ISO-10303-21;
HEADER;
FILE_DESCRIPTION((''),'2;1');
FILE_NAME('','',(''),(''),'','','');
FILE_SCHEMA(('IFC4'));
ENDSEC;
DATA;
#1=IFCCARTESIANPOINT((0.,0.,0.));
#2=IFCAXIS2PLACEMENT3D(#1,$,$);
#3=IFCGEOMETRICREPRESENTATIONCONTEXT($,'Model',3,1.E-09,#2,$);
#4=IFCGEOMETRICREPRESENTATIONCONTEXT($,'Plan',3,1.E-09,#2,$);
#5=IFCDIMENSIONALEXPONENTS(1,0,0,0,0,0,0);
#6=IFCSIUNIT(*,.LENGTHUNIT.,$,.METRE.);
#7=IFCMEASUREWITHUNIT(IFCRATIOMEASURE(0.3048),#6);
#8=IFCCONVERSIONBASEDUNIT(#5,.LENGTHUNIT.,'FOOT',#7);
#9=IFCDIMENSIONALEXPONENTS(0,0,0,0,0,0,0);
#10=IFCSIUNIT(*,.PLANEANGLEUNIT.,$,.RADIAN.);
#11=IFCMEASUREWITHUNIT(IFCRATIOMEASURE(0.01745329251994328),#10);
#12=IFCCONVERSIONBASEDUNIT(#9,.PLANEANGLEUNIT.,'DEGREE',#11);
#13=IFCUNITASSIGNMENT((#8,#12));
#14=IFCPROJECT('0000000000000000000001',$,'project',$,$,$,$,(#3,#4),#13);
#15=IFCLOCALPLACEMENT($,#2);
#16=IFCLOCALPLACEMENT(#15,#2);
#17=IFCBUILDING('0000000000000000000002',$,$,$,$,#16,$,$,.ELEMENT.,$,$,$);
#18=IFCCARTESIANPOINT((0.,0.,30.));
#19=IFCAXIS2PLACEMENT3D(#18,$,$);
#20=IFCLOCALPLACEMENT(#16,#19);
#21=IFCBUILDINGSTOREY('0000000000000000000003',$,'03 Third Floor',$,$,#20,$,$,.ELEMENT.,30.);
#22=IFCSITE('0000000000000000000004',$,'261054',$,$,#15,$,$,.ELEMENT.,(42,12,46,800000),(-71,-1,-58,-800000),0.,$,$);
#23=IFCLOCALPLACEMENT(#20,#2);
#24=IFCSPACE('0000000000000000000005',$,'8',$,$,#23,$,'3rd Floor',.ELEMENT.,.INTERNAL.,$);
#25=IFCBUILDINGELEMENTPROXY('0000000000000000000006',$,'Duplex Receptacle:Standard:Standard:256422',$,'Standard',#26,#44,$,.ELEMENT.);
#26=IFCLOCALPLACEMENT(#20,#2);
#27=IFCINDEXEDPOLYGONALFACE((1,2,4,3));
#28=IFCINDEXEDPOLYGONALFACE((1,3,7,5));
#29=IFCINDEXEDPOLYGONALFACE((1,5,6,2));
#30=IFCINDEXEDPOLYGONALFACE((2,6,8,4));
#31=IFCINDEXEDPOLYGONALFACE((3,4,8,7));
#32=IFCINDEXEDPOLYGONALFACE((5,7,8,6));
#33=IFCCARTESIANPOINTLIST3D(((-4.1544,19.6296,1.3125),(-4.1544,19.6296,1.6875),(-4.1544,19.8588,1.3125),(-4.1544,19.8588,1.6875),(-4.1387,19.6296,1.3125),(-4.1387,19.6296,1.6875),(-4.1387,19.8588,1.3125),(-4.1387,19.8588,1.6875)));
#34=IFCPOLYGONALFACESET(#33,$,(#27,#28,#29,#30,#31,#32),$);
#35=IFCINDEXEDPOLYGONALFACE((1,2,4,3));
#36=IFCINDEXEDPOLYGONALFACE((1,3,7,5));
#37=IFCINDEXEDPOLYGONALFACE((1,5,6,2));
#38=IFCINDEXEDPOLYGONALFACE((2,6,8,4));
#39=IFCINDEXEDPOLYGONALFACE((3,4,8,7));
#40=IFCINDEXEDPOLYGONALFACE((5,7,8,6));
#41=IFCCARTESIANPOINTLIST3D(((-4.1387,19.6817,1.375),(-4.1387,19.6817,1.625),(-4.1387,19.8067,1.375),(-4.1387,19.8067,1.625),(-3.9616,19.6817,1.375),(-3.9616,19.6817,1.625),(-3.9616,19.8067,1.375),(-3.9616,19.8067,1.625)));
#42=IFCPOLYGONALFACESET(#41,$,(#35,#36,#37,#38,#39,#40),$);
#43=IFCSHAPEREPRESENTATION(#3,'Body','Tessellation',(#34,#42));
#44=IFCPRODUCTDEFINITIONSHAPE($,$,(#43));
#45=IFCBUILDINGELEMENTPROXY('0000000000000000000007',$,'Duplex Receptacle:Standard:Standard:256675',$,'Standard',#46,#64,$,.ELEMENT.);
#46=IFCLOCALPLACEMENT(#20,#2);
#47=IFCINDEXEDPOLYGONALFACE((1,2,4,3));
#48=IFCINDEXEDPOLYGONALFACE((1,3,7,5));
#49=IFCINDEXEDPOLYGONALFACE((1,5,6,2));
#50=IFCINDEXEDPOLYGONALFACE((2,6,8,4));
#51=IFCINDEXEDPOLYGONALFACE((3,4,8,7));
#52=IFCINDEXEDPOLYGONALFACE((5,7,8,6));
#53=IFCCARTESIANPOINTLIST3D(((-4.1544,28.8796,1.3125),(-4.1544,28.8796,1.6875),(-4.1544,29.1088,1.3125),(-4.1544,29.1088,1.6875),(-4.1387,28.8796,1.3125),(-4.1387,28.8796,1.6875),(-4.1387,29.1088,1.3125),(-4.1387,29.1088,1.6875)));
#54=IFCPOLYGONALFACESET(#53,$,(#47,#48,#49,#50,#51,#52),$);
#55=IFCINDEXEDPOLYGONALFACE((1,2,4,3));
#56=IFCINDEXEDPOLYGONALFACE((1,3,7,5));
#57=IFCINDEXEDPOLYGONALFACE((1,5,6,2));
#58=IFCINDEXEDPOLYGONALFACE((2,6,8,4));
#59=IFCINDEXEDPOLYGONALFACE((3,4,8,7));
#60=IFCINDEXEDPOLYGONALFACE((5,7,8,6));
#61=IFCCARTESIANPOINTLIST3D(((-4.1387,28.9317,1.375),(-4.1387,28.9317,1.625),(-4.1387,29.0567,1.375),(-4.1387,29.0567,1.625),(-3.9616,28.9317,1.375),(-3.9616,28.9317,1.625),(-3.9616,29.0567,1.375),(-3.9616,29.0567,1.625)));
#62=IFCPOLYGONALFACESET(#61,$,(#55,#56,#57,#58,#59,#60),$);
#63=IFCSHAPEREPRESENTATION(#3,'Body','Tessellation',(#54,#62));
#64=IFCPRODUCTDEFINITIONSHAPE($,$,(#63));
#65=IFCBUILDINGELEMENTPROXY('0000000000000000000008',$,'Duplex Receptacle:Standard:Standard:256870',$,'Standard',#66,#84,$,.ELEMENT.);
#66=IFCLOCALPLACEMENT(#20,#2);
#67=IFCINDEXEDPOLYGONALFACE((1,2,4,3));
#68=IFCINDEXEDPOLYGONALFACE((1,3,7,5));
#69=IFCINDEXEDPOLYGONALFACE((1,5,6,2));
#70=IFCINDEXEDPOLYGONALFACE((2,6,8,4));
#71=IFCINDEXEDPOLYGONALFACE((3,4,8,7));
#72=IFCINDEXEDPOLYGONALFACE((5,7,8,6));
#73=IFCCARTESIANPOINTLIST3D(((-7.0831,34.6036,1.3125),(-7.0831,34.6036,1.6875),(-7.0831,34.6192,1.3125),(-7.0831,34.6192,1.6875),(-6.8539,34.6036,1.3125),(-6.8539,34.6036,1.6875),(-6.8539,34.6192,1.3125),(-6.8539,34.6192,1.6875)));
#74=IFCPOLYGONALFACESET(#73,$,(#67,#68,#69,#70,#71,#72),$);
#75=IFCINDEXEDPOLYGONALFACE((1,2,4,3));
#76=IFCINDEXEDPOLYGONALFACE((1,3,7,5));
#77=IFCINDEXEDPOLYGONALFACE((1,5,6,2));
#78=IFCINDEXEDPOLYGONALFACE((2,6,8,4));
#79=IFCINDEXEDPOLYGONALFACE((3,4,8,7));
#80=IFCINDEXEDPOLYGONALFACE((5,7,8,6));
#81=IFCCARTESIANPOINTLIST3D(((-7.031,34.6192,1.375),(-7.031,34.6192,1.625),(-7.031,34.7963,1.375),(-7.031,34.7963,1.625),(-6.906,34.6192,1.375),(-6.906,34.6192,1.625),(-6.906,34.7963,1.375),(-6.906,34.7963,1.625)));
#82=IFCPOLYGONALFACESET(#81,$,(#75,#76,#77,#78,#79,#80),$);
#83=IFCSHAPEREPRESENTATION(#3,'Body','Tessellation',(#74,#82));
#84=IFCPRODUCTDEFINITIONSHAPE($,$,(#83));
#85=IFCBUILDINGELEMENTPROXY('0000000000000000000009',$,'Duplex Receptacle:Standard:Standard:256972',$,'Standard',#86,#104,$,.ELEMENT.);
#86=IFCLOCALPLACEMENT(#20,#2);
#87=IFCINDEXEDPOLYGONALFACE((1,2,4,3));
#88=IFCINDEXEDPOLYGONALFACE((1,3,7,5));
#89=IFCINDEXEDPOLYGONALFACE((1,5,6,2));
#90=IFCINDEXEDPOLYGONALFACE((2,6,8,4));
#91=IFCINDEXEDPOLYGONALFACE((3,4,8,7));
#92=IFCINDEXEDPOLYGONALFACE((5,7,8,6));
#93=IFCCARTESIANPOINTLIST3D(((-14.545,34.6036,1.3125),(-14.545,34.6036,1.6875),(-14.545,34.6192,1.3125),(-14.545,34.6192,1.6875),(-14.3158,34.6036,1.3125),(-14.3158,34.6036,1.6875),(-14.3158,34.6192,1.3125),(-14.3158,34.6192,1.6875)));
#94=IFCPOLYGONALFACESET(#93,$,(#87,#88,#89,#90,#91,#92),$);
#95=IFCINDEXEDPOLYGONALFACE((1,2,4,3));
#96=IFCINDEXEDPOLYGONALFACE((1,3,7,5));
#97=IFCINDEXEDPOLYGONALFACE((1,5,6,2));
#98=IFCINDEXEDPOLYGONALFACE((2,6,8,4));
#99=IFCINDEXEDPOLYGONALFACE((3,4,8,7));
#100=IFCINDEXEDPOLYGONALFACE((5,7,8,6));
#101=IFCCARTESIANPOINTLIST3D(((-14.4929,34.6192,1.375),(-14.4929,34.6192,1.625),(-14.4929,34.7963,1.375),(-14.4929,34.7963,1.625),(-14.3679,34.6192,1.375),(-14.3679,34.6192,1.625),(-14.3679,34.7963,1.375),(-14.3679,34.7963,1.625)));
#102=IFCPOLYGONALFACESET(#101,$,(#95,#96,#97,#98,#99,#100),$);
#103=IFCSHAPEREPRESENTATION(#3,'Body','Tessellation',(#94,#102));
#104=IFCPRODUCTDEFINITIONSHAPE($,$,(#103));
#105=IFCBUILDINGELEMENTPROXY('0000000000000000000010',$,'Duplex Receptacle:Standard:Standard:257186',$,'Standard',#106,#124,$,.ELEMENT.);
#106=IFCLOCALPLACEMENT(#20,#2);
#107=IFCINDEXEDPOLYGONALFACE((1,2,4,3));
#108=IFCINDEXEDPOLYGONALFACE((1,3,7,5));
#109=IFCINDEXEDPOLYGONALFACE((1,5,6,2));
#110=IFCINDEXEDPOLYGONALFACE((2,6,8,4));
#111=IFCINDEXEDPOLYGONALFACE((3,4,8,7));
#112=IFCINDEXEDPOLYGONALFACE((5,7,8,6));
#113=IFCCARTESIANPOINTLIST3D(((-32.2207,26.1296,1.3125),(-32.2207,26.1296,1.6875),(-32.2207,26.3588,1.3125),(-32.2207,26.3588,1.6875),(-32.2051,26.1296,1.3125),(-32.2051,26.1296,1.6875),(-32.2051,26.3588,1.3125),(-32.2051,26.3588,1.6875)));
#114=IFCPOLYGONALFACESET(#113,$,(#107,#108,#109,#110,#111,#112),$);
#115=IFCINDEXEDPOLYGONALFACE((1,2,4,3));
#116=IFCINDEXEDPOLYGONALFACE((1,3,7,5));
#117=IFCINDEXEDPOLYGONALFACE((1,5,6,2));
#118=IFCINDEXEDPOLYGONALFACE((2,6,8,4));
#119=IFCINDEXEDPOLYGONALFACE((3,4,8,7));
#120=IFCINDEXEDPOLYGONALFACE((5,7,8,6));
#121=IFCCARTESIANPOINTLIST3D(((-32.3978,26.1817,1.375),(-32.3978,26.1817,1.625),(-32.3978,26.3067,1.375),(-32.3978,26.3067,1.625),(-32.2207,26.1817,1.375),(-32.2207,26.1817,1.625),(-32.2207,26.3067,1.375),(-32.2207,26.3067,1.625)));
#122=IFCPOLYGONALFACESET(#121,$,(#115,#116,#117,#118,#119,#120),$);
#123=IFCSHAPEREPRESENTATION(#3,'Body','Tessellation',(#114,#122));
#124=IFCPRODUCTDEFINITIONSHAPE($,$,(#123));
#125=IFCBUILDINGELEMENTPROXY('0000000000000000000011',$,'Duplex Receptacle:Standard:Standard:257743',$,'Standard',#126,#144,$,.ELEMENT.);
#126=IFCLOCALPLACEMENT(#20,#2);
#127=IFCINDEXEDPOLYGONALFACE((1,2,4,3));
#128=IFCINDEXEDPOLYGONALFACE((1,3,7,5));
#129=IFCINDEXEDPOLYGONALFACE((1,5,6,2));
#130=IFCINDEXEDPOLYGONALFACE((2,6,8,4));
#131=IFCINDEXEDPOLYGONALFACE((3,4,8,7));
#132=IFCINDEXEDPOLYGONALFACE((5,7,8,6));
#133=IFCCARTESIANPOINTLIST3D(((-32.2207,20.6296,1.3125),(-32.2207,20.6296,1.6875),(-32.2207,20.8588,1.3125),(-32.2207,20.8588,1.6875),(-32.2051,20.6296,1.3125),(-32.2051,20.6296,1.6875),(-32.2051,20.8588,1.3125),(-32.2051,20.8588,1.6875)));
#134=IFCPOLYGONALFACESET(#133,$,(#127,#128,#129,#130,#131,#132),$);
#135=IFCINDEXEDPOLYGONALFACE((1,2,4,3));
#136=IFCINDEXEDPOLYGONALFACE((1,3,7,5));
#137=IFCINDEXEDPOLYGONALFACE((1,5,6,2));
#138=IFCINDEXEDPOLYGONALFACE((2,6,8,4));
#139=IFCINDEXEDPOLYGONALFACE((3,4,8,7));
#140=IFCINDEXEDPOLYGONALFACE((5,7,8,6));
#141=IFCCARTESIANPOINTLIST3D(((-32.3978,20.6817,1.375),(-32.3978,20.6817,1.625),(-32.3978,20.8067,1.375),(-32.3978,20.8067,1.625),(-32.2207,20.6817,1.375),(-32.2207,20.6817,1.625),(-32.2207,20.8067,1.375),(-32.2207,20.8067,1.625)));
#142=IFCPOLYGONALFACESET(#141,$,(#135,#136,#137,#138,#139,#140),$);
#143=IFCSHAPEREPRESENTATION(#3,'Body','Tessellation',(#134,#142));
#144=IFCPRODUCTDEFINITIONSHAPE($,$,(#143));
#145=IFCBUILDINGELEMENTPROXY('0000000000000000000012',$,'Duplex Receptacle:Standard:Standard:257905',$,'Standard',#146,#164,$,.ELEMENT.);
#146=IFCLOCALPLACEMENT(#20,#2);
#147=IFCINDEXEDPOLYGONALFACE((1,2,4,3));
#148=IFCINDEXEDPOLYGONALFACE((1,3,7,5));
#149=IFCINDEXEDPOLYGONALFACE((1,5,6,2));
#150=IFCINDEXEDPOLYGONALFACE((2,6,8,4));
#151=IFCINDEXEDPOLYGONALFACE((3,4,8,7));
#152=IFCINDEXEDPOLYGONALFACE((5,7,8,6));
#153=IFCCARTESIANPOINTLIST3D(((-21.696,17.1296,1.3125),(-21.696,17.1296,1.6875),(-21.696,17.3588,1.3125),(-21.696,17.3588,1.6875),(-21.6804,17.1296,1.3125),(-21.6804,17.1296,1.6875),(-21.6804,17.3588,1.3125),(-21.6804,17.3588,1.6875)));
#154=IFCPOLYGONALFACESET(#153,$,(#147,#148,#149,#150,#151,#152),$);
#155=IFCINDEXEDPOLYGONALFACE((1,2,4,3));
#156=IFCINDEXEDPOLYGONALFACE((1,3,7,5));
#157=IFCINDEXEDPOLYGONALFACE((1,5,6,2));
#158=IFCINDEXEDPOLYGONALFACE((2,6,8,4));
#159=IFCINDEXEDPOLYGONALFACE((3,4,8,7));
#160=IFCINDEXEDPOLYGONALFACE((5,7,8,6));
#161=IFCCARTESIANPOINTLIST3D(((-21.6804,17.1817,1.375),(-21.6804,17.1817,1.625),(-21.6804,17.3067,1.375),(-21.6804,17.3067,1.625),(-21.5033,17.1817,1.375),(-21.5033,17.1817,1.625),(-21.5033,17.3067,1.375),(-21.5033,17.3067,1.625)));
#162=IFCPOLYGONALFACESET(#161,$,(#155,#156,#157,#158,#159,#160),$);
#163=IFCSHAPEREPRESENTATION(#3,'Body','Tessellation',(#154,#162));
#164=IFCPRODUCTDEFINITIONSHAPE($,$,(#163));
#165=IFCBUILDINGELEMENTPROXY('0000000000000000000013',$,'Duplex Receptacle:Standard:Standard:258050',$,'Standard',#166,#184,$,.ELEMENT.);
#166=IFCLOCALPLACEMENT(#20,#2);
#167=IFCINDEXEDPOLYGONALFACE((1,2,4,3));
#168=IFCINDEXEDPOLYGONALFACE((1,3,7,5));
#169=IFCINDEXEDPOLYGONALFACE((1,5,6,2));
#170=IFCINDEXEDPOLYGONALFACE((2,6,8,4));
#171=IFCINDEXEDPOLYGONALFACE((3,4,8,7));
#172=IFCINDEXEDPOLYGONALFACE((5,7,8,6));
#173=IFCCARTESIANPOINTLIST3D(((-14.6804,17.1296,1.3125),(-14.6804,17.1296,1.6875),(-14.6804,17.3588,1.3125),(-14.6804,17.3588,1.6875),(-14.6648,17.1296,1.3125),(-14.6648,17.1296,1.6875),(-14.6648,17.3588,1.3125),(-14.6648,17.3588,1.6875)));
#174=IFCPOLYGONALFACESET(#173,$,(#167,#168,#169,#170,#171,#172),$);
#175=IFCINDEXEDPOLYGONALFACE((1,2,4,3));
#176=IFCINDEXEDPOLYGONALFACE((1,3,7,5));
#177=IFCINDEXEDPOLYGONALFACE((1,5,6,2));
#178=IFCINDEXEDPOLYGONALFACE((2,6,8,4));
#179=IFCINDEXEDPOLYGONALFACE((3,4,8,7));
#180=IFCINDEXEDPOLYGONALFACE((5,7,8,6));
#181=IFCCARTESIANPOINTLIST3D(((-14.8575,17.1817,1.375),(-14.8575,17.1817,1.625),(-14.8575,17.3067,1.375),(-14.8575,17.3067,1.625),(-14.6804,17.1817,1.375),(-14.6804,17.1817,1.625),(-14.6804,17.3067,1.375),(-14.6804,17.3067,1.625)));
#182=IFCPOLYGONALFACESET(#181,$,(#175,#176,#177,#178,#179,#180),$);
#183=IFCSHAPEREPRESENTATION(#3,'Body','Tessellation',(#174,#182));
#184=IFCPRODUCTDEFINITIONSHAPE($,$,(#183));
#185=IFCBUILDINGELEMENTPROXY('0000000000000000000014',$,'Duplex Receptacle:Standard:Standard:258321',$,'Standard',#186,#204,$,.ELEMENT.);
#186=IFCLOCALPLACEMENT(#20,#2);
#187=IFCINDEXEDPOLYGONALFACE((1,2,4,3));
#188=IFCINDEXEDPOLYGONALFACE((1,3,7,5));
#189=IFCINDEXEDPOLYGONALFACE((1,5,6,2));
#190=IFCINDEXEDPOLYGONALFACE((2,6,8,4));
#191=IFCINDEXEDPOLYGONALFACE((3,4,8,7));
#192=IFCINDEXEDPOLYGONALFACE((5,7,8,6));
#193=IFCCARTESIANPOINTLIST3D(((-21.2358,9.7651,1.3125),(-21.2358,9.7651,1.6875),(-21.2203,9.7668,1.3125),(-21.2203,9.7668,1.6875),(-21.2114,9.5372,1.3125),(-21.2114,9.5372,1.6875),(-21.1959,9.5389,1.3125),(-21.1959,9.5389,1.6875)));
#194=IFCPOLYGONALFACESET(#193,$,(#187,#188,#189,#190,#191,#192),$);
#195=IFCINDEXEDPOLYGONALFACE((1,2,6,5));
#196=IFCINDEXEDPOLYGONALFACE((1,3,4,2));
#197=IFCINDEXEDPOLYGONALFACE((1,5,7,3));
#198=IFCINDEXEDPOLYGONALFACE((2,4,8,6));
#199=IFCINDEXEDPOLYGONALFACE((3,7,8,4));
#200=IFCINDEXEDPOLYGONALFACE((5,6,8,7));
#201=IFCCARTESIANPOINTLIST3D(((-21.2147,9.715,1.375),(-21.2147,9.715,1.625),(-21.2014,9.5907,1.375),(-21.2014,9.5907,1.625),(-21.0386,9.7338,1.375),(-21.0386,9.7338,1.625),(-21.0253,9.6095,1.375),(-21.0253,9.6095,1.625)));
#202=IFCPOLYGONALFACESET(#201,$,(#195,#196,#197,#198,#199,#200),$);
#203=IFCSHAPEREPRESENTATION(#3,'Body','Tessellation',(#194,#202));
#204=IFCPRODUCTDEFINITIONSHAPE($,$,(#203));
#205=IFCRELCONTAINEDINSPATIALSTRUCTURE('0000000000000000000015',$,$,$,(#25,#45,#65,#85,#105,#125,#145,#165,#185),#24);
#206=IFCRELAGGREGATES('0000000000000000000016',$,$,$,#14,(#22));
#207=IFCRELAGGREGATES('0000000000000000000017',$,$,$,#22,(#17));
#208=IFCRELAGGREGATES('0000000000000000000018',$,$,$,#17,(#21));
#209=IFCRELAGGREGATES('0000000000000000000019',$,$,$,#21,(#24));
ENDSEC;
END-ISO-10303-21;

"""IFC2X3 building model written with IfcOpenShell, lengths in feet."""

from ifc_helpers import new_model, entity, si_unit, converted_unit, frame, origin, origin_2d_with_axis, place, context, project, spatial, rectangle, extrude, source, transform, mapped, element, save


model = new_model("IFC2X3")

# Units and contexts
model_context = context("Model", 3, precision=1e-09, world=origin())
plan_context = context("Plan", 3, precision=1e-09, world=origin())
ifc_project = project(units=[converted_unit("LENGTHUNIT", "FOOT", entity("IfcRatioMeasure", 0.3048), si_unit("LENGTHUNIT", "METRE"), dimensions=[1, 0, 0, 0, 0, 0, 0]), converted_unit("PLANEANGLEUNIT", "DEGREE", entity("IfcRatioMeasure", 0.01745329251994328), si_unit("PLANEANGLEUNIT", "RADIAN"), dimensions=[0, 0, 0, 0, 0, 0, 0])], contexts=[model_context, plan_context])

# Site, building, storey
site_placement = place(None, origin())
site = spatial("IfcSite", under=ifc_project, at=site_placement, Name="261054", CompositionType="ELEMENT", RefLatitude=(42, 12, 46, 800000), RefLongitude=(-71, -1, -58, -800000), RefElevation=0.0)
building_placement = place(site_placement, origin())
building = spatial("IfcBuilding", under=site, at=building_placement, CompositionType="ELEMENT")
storey_placement = place(building_placement, frame((0.0, 0.0, 30.0)))
storey = spatial("IfcBuildingStorey", under=building, at=storey_placement, Name="03 Third Floor", CompositionType="ELEMENT", Elevation=30.0)

# Shared definitions
space_1_placement = place(storey_placement, origin())
space_1 = spatial("IfcSpace", under=storey, at=space_1_placement, Name="8", LongName="3rd Floor", CompositionType="ELEMENT", InteriorOrExteriorSpace="INTERNAL")

# Building element proxies
shared_shape_1 = source(origin(), model_context, "Body", "SweptSolid", [
    extrude(rectangle(XDim=0.2292, YDim=0.375, at=origin_2d_with_axis()), frame((0.0, 0.0, 0.0), z_axis=(0.0, 0.0, 1.0), x_axis=(-1.0, 0.0, 0.0)), (0.0, 0.0, 1.0), 0.0156),
    extrude(rectangle(XDim=0.125, YDim=0.25, at=origin_2d_with_axis()), frame((0.0, 0.0, -0.1771), z_axis=(0.0, 0.0, 1.0), x_axis=(-1.0, 0.0, 0.0)), (0.0, 0.0, 1.0), 0.1771),
])
for number, where, z_axis, x_axis, name in (
    (1, (-4.1387, 19.7442, 1.5), (-1.0, 0.0, 0.0), (0.0, -1.0, 0.0), "Duplex Receptacle:Standard:Standard:256422"),
    (2, (-4.1387, 28.9942, 1.5), (-1.0, 0.0, 0.0), (0.0, -1.0, 0.0), "Duplex Receptacle:Standard:Standard:256675"),
    (3, (-6.9685, 34.6192, 1.5), (0.0, -1.0, 0.0), (1.0, 0.0, 0.0), "Duplex Receptacle:Standard:Standard:256870"),
    (4, (-14.4304, 34.6192, 1.5), (0.0, -1.0, 0.0), (1.0, 0.0, 0.0), "Duplex Receptacle:Standard:Standard:256972"),
    (5, (-32.2207, 26.2442, 1.5), (1.0, 0.0, 0.0), (0.0, 1.0, 0.0), "Duplex Receptacle:Standard:Standard:257186"),
    (6, (-32.2207, 20.7442, 1.5), (1.0, 0.0, 0.0), (0.0, 1.0, 0.0), "Duplex Receptacle:Standard:Standard:257743"),
    (7, (-21.6804, 17.2442, 1.5), (-1.0, 0.0, 0.0), (0.0, -1.0, 0.0), "Duplex Receptacle:Standard:Standard:257905"),
    (8, (-14.6804, 17.2442, 1.5), (1.0, 0.0, 0.0), (0.0, 1.0, 0.0), "Duplex Receptacle:Standard:Standard:258050"),
    (9, (-21.2081, 9.6528, 1.5), (-0.994321, -0.106427, 0.0), (0.106427, -0.994321, 0.0), "Duplex Receptacle:Standard:Standard:258321"),
):
    element("IfcBuildingElementProxy", number, at=place(space_1_placement, frame(where, z_axis=z_axis, x_axis=x_axis)), inside=space_1, Name=name, ObjectType="Standard", CompositionType="ELEMENT", context=model_context, shape_type="MappedRepresentation", body=[
        mapped(shared_shape_1, transform((0.0, 0.0, 0.0), scale=1.0)),
    ])

save(model, "model.ifc")
